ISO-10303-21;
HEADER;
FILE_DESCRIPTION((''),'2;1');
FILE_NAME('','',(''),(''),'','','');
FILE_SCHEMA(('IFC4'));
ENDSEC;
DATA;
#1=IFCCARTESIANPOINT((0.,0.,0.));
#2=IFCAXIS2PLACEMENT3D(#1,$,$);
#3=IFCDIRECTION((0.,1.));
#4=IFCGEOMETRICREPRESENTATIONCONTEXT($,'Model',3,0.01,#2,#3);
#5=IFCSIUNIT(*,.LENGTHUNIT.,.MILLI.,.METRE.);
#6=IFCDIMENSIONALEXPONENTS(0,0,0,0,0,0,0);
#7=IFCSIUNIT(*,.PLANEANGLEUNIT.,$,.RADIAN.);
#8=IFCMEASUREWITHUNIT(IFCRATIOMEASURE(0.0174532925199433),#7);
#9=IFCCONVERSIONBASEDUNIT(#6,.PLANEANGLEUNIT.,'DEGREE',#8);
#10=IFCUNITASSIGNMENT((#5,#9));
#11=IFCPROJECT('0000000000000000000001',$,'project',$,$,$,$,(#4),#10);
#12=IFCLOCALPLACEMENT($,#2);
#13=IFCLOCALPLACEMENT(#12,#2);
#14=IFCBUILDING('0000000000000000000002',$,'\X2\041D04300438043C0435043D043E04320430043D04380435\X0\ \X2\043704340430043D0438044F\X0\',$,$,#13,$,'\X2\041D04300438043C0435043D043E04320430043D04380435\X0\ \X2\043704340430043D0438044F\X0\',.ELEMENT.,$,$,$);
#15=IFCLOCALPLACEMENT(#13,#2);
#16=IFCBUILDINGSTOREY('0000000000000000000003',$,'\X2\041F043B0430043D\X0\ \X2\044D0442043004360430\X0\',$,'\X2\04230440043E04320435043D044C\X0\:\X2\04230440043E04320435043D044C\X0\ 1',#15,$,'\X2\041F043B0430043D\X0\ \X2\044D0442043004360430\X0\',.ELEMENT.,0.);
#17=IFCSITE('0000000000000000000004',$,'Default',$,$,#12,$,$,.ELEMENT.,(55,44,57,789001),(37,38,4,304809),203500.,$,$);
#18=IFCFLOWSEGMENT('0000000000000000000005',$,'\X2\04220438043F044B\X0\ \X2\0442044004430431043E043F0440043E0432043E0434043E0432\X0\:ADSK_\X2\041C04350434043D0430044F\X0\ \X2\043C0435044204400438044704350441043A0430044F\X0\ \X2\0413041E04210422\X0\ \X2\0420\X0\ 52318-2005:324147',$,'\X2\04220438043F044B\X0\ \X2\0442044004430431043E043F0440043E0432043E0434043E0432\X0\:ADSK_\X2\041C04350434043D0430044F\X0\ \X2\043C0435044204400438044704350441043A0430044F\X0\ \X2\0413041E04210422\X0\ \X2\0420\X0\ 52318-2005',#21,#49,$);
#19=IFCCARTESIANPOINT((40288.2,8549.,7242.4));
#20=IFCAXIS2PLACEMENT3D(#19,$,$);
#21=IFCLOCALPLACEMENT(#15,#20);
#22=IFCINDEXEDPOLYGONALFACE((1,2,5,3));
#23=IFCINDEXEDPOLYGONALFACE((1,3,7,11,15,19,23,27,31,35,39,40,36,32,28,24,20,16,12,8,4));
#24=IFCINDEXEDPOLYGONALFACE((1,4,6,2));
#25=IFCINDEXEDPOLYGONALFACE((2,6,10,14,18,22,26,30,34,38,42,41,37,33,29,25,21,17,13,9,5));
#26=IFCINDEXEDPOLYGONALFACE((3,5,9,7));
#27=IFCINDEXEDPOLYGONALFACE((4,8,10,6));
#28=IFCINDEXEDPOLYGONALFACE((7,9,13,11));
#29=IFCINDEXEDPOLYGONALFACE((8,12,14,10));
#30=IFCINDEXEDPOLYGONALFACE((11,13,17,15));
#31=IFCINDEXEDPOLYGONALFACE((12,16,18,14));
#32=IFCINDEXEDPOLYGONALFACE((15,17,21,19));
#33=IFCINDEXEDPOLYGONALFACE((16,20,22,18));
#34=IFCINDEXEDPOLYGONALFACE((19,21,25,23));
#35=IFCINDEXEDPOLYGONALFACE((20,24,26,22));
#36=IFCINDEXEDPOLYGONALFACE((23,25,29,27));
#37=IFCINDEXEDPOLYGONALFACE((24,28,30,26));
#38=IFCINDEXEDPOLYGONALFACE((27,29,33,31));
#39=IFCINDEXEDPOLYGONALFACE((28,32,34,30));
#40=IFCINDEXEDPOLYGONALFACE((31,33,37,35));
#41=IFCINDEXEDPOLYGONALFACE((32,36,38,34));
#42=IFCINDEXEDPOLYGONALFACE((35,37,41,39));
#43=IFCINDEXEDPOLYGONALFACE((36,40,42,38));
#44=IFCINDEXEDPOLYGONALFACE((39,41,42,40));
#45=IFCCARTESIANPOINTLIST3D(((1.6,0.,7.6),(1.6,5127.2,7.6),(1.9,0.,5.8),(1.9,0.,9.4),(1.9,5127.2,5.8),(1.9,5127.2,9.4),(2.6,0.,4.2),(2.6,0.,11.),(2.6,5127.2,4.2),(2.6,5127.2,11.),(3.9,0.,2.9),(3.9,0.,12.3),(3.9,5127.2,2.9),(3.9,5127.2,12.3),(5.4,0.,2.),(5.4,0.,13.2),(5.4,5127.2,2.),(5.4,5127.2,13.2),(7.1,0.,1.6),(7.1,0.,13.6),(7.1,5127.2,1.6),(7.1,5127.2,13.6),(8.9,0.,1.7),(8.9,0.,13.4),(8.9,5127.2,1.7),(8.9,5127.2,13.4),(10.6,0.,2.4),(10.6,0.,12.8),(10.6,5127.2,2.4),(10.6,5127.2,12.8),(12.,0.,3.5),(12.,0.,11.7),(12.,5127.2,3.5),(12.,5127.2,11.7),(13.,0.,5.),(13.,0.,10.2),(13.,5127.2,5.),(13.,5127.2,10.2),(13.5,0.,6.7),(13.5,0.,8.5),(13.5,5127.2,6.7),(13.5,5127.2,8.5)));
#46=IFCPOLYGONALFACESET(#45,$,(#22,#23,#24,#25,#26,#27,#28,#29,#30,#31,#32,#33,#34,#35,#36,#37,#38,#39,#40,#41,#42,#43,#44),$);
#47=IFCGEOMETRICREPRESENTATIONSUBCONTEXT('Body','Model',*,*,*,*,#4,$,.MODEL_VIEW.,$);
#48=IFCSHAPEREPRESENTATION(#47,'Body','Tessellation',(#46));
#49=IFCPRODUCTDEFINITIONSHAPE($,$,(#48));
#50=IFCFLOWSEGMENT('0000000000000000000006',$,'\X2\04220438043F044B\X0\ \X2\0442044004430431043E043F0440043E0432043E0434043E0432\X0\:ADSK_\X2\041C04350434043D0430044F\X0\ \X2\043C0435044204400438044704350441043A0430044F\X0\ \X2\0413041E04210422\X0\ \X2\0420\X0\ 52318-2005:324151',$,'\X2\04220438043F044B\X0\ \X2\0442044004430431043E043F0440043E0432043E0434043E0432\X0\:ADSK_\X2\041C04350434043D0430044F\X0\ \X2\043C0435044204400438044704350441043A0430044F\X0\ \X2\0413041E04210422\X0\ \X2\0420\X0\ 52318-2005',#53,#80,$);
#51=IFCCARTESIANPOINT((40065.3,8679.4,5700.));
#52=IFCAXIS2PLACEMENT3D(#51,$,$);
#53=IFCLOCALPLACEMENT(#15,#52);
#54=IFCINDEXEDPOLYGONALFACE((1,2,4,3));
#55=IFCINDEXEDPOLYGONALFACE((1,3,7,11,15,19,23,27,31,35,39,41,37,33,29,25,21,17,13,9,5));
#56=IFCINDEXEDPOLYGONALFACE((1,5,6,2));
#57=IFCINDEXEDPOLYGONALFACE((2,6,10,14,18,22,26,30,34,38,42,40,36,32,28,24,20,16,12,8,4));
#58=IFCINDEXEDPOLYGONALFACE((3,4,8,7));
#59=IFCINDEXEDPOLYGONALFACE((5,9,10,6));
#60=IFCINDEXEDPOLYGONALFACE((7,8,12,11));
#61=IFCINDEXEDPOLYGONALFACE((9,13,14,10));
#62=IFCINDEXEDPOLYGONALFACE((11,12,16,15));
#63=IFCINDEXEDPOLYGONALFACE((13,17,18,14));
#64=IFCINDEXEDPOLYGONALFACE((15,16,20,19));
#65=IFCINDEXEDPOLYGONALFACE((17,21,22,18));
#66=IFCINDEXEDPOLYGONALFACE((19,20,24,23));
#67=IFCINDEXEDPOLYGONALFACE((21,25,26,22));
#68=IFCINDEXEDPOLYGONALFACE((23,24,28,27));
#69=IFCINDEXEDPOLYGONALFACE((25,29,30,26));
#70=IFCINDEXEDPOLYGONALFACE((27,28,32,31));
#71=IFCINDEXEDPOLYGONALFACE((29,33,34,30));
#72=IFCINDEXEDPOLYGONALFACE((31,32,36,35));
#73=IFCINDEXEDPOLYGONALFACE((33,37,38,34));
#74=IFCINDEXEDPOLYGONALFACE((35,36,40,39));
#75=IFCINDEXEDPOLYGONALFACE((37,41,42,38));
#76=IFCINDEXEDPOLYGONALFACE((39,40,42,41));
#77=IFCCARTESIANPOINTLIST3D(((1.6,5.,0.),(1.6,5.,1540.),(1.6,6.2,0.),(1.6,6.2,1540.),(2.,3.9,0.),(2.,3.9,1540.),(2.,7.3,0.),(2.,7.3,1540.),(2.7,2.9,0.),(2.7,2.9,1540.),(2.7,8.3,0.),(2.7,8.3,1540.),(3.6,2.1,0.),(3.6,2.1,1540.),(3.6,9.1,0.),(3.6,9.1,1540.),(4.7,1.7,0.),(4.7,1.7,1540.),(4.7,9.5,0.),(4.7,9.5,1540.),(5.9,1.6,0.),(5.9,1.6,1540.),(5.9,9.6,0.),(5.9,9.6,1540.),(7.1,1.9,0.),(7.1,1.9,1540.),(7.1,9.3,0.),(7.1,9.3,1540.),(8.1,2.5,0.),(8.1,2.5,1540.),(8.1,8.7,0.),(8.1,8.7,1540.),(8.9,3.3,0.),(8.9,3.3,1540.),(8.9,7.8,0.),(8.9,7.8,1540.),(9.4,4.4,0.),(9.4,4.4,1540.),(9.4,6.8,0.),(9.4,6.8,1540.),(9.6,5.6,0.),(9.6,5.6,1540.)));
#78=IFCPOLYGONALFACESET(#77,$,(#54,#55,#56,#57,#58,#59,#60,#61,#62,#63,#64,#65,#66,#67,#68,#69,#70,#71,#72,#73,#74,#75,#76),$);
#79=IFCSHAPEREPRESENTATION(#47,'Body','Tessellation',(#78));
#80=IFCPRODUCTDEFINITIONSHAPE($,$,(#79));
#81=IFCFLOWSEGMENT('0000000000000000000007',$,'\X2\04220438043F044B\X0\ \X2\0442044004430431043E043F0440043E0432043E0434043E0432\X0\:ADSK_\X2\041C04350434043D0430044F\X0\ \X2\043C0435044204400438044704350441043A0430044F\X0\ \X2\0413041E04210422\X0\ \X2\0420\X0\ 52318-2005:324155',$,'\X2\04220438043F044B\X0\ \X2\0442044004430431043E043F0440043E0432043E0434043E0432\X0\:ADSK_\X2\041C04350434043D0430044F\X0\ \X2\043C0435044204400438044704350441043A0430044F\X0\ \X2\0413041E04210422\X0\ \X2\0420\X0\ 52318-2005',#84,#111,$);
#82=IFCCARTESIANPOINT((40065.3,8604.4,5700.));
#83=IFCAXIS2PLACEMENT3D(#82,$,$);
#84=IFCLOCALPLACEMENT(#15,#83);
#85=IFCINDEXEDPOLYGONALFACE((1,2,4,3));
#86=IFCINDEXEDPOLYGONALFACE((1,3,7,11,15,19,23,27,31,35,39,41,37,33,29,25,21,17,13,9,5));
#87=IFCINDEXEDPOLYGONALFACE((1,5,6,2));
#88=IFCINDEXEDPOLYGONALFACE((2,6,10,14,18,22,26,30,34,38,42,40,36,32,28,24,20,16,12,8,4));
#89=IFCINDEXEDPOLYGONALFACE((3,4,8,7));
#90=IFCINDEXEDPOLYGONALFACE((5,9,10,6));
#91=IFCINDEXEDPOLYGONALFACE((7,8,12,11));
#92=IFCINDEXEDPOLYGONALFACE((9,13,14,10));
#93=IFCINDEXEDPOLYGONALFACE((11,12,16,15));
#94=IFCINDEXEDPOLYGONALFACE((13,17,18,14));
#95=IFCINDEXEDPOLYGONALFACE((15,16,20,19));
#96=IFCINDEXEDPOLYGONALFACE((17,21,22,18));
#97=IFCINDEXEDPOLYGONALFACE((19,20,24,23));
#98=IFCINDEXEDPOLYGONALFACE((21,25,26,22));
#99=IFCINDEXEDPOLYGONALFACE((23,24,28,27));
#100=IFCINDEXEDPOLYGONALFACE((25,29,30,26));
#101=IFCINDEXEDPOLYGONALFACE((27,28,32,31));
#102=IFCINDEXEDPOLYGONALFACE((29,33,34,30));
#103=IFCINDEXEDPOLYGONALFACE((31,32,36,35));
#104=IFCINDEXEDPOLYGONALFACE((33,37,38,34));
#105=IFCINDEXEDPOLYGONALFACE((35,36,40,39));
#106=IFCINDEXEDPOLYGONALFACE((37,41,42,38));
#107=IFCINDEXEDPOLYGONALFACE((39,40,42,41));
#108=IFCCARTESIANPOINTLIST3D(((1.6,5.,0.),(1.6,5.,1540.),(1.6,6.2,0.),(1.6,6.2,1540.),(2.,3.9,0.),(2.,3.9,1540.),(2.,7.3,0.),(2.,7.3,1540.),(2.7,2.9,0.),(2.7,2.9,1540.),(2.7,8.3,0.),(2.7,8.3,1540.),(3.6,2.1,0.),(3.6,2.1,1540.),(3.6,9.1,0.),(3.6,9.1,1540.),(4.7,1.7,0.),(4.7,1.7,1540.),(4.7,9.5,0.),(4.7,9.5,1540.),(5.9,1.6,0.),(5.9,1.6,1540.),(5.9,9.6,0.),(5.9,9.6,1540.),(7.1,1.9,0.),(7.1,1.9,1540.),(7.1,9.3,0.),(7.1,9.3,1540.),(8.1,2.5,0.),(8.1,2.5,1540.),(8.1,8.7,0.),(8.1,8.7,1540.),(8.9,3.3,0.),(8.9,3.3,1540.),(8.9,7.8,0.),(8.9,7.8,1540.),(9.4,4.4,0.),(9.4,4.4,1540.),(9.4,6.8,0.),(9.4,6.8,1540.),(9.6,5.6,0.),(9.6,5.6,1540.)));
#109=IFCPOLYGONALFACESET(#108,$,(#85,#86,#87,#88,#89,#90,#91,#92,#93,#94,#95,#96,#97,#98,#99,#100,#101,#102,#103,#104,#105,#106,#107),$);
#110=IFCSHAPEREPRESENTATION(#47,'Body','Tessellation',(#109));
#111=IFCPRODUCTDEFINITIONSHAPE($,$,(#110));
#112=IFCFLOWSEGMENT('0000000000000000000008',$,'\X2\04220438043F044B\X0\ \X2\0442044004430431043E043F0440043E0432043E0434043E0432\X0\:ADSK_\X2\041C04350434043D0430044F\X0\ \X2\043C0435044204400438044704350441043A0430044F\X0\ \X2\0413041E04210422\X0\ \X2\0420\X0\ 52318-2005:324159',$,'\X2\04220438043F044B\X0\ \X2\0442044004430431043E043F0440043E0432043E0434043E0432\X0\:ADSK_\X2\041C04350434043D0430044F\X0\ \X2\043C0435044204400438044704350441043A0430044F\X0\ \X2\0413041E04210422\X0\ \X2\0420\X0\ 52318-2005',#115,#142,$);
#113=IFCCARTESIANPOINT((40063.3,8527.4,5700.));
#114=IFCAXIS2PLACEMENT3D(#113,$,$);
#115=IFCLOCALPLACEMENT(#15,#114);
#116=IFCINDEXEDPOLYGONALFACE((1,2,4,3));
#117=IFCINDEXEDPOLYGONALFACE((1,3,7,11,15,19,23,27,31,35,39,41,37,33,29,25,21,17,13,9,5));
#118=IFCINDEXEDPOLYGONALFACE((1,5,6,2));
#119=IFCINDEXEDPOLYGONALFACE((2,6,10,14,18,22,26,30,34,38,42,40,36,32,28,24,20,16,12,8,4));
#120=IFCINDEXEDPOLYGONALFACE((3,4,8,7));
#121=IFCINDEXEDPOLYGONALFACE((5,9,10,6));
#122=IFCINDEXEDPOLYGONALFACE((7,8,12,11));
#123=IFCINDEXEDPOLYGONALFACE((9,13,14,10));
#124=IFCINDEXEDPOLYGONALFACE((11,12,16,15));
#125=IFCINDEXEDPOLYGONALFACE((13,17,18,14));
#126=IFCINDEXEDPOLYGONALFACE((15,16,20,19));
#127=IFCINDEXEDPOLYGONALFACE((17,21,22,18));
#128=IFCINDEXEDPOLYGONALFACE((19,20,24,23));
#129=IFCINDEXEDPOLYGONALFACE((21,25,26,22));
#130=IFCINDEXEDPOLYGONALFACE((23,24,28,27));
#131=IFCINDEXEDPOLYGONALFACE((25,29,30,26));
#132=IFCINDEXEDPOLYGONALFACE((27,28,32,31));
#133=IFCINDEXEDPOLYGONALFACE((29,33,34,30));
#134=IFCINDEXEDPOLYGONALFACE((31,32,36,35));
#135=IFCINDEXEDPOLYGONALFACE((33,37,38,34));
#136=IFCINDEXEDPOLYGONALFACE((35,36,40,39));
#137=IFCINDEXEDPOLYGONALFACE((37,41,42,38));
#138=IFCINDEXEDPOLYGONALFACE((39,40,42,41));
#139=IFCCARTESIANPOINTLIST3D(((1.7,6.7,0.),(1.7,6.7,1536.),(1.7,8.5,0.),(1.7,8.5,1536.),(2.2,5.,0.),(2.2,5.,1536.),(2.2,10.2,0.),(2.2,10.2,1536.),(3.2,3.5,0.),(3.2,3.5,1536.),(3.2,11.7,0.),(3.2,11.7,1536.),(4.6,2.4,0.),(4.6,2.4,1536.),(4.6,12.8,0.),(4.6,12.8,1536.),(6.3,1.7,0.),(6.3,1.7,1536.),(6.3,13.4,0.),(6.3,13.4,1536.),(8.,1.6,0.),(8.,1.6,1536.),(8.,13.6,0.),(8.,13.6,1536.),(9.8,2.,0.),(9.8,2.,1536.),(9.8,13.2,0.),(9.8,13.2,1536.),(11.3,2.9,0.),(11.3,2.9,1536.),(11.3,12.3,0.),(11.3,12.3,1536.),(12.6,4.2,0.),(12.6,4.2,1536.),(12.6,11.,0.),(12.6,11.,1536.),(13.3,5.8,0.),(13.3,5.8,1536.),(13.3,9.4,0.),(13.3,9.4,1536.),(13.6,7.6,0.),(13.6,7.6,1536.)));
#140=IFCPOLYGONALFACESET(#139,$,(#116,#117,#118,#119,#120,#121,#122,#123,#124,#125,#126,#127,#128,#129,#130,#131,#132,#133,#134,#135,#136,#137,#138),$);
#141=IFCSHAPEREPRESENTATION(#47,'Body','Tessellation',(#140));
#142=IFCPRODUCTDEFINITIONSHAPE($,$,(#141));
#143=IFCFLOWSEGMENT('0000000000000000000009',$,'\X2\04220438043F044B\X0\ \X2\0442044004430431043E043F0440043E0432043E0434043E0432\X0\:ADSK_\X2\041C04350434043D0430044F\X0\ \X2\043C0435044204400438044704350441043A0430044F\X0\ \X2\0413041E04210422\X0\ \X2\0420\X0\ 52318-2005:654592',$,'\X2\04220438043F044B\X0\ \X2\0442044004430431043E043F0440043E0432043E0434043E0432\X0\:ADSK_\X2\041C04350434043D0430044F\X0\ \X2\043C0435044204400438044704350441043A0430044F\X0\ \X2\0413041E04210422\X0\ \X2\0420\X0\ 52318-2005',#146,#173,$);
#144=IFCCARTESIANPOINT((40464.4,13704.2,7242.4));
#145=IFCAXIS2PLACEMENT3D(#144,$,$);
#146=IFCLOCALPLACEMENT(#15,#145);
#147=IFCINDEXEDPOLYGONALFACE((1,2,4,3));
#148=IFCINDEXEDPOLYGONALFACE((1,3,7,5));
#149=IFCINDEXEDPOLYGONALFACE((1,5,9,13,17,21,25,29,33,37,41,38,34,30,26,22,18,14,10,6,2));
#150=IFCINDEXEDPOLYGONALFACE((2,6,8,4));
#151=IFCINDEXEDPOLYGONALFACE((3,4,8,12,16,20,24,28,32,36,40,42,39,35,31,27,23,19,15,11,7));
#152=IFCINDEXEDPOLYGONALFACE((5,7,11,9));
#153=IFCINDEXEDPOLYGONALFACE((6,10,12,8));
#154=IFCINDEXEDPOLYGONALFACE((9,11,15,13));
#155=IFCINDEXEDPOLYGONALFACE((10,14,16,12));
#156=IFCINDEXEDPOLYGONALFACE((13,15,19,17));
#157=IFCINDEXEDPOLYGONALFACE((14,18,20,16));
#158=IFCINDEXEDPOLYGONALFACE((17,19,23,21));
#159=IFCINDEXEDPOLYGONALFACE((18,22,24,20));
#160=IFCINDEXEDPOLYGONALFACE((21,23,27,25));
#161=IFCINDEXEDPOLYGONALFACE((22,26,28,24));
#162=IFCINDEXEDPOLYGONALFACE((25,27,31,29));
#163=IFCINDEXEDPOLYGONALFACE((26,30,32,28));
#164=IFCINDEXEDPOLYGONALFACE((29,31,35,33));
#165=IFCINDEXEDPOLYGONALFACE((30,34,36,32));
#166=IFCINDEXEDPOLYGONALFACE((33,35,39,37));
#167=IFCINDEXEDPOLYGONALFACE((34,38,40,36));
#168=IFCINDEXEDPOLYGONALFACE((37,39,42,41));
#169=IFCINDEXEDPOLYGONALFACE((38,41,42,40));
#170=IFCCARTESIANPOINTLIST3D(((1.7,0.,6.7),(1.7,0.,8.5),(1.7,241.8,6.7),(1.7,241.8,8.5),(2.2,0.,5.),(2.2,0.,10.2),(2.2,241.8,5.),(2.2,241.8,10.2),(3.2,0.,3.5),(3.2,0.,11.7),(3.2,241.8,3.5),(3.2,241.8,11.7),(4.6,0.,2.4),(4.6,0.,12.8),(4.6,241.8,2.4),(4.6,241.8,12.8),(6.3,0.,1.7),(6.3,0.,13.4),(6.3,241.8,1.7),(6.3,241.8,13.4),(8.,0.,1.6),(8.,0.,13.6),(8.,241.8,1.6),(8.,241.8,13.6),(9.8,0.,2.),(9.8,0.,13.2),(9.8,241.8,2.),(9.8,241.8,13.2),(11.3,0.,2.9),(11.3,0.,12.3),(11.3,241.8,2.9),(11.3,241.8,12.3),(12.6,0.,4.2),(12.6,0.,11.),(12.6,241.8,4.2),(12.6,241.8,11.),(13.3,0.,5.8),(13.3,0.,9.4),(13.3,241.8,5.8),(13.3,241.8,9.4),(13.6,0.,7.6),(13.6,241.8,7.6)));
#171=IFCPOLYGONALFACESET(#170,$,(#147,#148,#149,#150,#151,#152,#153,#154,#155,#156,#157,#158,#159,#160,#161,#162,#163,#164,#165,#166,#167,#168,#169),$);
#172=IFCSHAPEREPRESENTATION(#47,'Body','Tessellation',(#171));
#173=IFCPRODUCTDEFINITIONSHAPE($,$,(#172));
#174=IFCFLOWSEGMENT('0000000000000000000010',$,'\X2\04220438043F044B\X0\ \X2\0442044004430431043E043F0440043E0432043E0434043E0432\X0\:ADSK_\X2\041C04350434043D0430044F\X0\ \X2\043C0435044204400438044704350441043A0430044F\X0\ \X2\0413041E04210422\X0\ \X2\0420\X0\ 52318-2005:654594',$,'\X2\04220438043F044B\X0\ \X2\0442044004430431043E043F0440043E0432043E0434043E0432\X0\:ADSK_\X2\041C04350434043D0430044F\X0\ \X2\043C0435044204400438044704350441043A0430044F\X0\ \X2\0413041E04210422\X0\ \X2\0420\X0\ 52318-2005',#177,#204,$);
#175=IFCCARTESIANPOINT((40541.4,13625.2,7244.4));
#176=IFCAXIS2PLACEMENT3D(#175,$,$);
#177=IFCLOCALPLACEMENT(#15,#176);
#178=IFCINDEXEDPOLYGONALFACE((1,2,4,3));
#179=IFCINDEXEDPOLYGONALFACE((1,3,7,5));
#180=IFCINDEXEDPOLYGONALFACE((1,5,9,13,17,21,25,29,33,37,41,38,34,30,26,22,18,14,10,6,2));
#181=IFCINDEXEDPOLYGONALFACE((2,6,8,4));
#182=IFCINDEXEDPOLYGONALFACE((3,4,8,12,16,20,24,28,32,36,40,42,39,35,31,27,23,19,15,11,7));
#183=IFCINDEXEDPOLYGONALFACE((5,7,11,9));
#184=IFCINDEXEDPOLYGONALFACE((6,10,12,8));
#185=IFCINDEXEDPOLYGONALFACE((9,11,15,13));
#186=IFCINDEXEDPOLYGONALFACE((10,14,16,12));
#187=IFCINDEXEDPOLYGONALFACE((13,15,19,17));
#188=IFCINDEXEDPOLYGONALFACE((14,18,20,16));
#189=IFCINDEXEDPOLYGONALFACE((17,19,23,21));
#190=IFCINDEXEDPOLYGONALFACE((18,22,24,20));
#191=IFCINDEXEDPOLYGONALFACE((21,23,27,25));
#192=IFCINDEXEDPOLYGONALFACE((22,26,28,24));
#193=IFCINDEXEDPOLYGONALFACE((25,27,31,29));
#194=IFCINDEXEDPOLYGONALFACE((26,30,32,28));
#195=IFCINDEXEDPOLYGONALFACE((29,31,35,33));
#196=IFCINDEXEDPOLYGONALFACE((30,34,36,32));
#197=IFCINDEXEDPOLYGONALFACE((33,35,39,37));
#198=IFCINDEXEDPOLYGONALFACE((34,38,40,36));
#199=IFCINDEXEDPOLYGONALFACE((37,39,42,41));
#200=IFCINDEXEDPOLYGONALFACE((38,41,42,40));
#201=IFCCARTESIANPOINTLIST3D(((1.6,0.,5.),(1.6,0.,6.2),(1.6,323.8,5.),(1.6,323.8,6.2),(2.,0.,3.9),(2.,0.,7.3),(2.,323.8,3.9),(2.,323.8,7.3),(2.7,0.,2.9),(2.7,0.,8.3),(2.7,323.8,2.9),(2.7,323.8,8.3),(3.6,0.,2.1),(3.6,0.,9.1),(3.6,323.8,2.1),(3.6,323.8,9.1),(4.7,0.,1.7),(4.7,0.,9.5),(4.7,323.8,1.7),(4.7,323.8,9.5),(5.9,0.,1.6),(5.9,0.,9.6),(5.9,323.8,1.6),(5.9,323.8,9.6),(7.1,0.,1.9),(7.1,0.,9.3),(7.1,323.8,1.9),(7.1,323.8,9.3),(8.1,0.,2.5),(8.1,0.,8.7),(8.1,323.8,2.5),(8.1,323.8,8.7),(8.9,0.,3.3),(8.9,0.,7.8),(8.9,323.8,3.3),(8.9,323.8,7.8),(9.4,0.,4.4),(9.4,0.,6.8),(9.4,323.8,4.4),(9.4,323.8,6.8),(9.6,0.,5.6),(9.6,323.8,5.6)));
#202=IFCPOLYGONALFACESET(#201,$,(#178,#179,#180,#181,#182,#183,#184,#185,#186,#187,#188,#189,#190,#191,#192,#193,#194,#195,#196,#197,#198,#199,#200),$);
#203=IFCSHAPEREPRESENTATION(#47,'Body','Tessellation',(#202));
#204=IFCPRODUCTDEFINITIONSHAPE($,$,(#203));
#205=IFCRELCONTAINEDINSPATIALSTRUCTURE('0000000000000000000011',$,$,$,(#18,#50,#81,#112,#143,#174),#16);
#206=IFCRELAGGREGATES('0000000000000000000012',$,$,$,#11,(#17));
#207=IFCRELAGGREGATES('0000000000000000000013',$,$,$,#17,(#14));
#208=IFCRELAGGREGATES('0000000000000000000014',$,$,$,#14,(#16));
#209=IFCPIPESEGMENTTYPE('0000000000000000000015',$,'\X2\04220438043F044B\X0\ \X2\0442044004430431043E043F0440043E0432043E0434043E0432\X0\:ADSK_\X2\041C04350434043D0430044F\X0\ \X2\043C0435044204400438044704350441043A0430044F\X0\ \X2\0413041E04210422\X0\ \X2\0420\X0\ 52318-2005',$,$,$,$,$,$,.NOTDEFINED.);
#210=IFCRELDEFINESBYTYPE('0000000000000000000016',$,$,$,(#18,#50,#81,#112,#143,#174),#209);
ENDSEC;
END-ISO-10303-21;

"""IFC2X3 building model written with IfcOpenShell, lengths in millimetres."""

from ifc_helpers import new_model, entity, si_unit, converted_unit, direction, frame, frame_2d, origin, origin_2d_with_axis, place, context, subcontext, project, spatial, circle, extrude, type_object, element, save


model = new_model("IFC2X3")

# Units and contexts
model_context = context("Model", 3, precision=0.01, world=origin(), true_north=direction((0.0, 1.0)))
body_context = subcontext(model_context, "Body", "Model", "MODEL_VIEW")
ifc_project = project(units=[si_unit("LENGTHUNIT", "METRE", prefix="MILLI"), converted_unit("PLANEANGLEUNIT", "DEGREE", entity("IfcRatioMeasure", 0.0174532925199433), si_unit("PLANEANGLEUNIT", "RADIAN"), dimensions=[0, 0, 0, 0, 0, 0, 0])], contexts=[model_context])

# Site, building, storey
site_placement = place(None, frame((0.0, 0.0, 0.0)))
site = spatial("IfcSite", under=ifc_project, at=site_placement, Name="Default", CompositionType="ELEMENT", RefLatitude=(55, 44, 57, 789001), RefLongitude=(37, 38, 4, 304809), RefElevation=203500.0)
building_placement = place(site_placement, origin())
building = spatial("IfcBuilding", under=site, at=building_placement, Name="Наименование здания", LongName="Наименование здания", CompositionType="ELEMENT")
storey_placement = place(building_placement, origin())
storey = spatial("IfcBuildingStorey", under=building, at=storey_placement, Name="План этажа", ObjectType="Уровень:Уровень 1", LongName="План этажа", CompositionType="ELEMENT", Elevation=0.0)

# Flow segments
pipe_segment_type = type_object("IfcPipeSegmentType", Name="Типы трубопроводов:ADSK_Медная метрическая ГОСТ Р 52318-2005", PredefinedType="NOTDEFINED")
flow_segment_1_placement = place(storey_placement, frame((40288.2, 8549.0, 7242.4)))
element("IfcFlowSegment", 1, at=flow_segment_1_placement, inside=storey, type_object=pipe_segment_type, Name="Типы трубопроводов:ADSK_Медная метрическая ГОСТ Р 52318-2005:324147", ObjectType="Типы трубопроводов:ADSK_Медная метрическая ГОСТ Р 52318-2005", context=body_context, shape_type="SweptSolid", body=[
    extrude(circle(Radius=6.0, at=frame_2d((0.0, 0.0), x_axis=(1.0, 0.0))), frame((7.6, 0.0, 7.6), z_axis=(0.0, 1.0, 0.0), x_axis=(-1.0, 0.0, 0.0)), (0.0, 0.0, 1.0), 5127.2),
])
for number, where, name in (
    (2, (40065.3, 8679.4, 5700.0), "Типы трубопроводов:ADSK_Медная метрическая ГОСТ Р 52318-2005:324151"),
    (3, (40065.3, 8604.4, 5700.0), "Типы трубопроводов:ADSK_Медная метрическая ГОСТ Р 52318-2005:324155"),
):
    element("IfcFlowSegment", number, at=place(storey_placement, frame(where)), inside=storey, type_object=pipe_segment_type, Name=name, ObjectType="Типы трубопроводов:ADSK_Медная метрическая ГОСТ Р 52318-2005", context=body_context, shape_type="SweptSolid", body=[
        extrude(circle(Radius=4.0, at=frame_2d((0.0, 0.0), x_axis=(1.0, 0.0))), frame((5.6, 5.6, 0.0)), (0.0, 0.0, 1.0), 1540.0),
    ])
flow_segment_2_placement = place(storey_placement, frame((40063.3, 8527.4, 5700.0)))
element("IfcFlowSegment", 4, at=flow_segment_2_placement, inside=storey, type_object=pipe_segment_type, Name="Типы трубопроводов:ADSK_Медная метрическая ГОСТ Р 52318-2005:324159", ObjectType="Типы трубопроводов:ADSK_Медная метрическая ГОСТ Р 52318-2005", context=body_context, shape_type="SweptSolid", body=[
    extrude(circle(Radius=6.0, at=frame_2d((0.0, 0.0), x_axis=(1.0, 0.0))), frame((7.6, 7.6, 0.0)), (0.0, 0.0, 1.0), 1536.0),
])
flow_segment_3_placement = place(storey_placement, frame((40464.4, 13704.2, 7242.4)))
element("IfcFlowSegment", 5, at=flow_segment_3_placement, inside=storey, type_object=pipe_segment_type, Name="Типы трубопроводов:ADSK_Медная метрическая ГОСТ Р 52318-2005:654592", ObjectType="Типы трубопроводов:ADSK_Медная метрическая ГОСТ Р 52318-2005", context=body_context, shape_type="SweptSolid", body=[
    extrude(circle(Radius=6.0, at=origin_2d_with_axis()), frame((7.6, 0.0, 7.6), z_axis=(0.0, 1.0, 0.0), x_axis=(1.0, 0.0, 0.0)), (0.0, 0.0, 1.0), 241.8),
])
flow_segment_4_placement = place(storey_placement, frame((40541.4, 13625.2, 7244.4)))
element("IfcFlowSegment", 6, at=flow_segment_4_placement, inside=storey, type_object=pipe_segment_type, Name="Типы трубопроводов:ADSK_Медная метрическая ГОСТ Р 52318-2005:654594", ObjectType="Типы трубопроводов:ADSK_Медная метрическая ГОСТ Р 52318-2005", context=body_context, shape_type="SweptSolid", body=[
    extrude(circle(Radius=4.0, at=origin_2d_with_axis()), frame((5.6, 0.0, 5.6), z_axis=(0.0, 1.0, 0.0), x_axis=(1.0, 0.0, 0.0)), (0.0, 0.0, 1.0), 323.8),
])

save(model, "model.ifc")
